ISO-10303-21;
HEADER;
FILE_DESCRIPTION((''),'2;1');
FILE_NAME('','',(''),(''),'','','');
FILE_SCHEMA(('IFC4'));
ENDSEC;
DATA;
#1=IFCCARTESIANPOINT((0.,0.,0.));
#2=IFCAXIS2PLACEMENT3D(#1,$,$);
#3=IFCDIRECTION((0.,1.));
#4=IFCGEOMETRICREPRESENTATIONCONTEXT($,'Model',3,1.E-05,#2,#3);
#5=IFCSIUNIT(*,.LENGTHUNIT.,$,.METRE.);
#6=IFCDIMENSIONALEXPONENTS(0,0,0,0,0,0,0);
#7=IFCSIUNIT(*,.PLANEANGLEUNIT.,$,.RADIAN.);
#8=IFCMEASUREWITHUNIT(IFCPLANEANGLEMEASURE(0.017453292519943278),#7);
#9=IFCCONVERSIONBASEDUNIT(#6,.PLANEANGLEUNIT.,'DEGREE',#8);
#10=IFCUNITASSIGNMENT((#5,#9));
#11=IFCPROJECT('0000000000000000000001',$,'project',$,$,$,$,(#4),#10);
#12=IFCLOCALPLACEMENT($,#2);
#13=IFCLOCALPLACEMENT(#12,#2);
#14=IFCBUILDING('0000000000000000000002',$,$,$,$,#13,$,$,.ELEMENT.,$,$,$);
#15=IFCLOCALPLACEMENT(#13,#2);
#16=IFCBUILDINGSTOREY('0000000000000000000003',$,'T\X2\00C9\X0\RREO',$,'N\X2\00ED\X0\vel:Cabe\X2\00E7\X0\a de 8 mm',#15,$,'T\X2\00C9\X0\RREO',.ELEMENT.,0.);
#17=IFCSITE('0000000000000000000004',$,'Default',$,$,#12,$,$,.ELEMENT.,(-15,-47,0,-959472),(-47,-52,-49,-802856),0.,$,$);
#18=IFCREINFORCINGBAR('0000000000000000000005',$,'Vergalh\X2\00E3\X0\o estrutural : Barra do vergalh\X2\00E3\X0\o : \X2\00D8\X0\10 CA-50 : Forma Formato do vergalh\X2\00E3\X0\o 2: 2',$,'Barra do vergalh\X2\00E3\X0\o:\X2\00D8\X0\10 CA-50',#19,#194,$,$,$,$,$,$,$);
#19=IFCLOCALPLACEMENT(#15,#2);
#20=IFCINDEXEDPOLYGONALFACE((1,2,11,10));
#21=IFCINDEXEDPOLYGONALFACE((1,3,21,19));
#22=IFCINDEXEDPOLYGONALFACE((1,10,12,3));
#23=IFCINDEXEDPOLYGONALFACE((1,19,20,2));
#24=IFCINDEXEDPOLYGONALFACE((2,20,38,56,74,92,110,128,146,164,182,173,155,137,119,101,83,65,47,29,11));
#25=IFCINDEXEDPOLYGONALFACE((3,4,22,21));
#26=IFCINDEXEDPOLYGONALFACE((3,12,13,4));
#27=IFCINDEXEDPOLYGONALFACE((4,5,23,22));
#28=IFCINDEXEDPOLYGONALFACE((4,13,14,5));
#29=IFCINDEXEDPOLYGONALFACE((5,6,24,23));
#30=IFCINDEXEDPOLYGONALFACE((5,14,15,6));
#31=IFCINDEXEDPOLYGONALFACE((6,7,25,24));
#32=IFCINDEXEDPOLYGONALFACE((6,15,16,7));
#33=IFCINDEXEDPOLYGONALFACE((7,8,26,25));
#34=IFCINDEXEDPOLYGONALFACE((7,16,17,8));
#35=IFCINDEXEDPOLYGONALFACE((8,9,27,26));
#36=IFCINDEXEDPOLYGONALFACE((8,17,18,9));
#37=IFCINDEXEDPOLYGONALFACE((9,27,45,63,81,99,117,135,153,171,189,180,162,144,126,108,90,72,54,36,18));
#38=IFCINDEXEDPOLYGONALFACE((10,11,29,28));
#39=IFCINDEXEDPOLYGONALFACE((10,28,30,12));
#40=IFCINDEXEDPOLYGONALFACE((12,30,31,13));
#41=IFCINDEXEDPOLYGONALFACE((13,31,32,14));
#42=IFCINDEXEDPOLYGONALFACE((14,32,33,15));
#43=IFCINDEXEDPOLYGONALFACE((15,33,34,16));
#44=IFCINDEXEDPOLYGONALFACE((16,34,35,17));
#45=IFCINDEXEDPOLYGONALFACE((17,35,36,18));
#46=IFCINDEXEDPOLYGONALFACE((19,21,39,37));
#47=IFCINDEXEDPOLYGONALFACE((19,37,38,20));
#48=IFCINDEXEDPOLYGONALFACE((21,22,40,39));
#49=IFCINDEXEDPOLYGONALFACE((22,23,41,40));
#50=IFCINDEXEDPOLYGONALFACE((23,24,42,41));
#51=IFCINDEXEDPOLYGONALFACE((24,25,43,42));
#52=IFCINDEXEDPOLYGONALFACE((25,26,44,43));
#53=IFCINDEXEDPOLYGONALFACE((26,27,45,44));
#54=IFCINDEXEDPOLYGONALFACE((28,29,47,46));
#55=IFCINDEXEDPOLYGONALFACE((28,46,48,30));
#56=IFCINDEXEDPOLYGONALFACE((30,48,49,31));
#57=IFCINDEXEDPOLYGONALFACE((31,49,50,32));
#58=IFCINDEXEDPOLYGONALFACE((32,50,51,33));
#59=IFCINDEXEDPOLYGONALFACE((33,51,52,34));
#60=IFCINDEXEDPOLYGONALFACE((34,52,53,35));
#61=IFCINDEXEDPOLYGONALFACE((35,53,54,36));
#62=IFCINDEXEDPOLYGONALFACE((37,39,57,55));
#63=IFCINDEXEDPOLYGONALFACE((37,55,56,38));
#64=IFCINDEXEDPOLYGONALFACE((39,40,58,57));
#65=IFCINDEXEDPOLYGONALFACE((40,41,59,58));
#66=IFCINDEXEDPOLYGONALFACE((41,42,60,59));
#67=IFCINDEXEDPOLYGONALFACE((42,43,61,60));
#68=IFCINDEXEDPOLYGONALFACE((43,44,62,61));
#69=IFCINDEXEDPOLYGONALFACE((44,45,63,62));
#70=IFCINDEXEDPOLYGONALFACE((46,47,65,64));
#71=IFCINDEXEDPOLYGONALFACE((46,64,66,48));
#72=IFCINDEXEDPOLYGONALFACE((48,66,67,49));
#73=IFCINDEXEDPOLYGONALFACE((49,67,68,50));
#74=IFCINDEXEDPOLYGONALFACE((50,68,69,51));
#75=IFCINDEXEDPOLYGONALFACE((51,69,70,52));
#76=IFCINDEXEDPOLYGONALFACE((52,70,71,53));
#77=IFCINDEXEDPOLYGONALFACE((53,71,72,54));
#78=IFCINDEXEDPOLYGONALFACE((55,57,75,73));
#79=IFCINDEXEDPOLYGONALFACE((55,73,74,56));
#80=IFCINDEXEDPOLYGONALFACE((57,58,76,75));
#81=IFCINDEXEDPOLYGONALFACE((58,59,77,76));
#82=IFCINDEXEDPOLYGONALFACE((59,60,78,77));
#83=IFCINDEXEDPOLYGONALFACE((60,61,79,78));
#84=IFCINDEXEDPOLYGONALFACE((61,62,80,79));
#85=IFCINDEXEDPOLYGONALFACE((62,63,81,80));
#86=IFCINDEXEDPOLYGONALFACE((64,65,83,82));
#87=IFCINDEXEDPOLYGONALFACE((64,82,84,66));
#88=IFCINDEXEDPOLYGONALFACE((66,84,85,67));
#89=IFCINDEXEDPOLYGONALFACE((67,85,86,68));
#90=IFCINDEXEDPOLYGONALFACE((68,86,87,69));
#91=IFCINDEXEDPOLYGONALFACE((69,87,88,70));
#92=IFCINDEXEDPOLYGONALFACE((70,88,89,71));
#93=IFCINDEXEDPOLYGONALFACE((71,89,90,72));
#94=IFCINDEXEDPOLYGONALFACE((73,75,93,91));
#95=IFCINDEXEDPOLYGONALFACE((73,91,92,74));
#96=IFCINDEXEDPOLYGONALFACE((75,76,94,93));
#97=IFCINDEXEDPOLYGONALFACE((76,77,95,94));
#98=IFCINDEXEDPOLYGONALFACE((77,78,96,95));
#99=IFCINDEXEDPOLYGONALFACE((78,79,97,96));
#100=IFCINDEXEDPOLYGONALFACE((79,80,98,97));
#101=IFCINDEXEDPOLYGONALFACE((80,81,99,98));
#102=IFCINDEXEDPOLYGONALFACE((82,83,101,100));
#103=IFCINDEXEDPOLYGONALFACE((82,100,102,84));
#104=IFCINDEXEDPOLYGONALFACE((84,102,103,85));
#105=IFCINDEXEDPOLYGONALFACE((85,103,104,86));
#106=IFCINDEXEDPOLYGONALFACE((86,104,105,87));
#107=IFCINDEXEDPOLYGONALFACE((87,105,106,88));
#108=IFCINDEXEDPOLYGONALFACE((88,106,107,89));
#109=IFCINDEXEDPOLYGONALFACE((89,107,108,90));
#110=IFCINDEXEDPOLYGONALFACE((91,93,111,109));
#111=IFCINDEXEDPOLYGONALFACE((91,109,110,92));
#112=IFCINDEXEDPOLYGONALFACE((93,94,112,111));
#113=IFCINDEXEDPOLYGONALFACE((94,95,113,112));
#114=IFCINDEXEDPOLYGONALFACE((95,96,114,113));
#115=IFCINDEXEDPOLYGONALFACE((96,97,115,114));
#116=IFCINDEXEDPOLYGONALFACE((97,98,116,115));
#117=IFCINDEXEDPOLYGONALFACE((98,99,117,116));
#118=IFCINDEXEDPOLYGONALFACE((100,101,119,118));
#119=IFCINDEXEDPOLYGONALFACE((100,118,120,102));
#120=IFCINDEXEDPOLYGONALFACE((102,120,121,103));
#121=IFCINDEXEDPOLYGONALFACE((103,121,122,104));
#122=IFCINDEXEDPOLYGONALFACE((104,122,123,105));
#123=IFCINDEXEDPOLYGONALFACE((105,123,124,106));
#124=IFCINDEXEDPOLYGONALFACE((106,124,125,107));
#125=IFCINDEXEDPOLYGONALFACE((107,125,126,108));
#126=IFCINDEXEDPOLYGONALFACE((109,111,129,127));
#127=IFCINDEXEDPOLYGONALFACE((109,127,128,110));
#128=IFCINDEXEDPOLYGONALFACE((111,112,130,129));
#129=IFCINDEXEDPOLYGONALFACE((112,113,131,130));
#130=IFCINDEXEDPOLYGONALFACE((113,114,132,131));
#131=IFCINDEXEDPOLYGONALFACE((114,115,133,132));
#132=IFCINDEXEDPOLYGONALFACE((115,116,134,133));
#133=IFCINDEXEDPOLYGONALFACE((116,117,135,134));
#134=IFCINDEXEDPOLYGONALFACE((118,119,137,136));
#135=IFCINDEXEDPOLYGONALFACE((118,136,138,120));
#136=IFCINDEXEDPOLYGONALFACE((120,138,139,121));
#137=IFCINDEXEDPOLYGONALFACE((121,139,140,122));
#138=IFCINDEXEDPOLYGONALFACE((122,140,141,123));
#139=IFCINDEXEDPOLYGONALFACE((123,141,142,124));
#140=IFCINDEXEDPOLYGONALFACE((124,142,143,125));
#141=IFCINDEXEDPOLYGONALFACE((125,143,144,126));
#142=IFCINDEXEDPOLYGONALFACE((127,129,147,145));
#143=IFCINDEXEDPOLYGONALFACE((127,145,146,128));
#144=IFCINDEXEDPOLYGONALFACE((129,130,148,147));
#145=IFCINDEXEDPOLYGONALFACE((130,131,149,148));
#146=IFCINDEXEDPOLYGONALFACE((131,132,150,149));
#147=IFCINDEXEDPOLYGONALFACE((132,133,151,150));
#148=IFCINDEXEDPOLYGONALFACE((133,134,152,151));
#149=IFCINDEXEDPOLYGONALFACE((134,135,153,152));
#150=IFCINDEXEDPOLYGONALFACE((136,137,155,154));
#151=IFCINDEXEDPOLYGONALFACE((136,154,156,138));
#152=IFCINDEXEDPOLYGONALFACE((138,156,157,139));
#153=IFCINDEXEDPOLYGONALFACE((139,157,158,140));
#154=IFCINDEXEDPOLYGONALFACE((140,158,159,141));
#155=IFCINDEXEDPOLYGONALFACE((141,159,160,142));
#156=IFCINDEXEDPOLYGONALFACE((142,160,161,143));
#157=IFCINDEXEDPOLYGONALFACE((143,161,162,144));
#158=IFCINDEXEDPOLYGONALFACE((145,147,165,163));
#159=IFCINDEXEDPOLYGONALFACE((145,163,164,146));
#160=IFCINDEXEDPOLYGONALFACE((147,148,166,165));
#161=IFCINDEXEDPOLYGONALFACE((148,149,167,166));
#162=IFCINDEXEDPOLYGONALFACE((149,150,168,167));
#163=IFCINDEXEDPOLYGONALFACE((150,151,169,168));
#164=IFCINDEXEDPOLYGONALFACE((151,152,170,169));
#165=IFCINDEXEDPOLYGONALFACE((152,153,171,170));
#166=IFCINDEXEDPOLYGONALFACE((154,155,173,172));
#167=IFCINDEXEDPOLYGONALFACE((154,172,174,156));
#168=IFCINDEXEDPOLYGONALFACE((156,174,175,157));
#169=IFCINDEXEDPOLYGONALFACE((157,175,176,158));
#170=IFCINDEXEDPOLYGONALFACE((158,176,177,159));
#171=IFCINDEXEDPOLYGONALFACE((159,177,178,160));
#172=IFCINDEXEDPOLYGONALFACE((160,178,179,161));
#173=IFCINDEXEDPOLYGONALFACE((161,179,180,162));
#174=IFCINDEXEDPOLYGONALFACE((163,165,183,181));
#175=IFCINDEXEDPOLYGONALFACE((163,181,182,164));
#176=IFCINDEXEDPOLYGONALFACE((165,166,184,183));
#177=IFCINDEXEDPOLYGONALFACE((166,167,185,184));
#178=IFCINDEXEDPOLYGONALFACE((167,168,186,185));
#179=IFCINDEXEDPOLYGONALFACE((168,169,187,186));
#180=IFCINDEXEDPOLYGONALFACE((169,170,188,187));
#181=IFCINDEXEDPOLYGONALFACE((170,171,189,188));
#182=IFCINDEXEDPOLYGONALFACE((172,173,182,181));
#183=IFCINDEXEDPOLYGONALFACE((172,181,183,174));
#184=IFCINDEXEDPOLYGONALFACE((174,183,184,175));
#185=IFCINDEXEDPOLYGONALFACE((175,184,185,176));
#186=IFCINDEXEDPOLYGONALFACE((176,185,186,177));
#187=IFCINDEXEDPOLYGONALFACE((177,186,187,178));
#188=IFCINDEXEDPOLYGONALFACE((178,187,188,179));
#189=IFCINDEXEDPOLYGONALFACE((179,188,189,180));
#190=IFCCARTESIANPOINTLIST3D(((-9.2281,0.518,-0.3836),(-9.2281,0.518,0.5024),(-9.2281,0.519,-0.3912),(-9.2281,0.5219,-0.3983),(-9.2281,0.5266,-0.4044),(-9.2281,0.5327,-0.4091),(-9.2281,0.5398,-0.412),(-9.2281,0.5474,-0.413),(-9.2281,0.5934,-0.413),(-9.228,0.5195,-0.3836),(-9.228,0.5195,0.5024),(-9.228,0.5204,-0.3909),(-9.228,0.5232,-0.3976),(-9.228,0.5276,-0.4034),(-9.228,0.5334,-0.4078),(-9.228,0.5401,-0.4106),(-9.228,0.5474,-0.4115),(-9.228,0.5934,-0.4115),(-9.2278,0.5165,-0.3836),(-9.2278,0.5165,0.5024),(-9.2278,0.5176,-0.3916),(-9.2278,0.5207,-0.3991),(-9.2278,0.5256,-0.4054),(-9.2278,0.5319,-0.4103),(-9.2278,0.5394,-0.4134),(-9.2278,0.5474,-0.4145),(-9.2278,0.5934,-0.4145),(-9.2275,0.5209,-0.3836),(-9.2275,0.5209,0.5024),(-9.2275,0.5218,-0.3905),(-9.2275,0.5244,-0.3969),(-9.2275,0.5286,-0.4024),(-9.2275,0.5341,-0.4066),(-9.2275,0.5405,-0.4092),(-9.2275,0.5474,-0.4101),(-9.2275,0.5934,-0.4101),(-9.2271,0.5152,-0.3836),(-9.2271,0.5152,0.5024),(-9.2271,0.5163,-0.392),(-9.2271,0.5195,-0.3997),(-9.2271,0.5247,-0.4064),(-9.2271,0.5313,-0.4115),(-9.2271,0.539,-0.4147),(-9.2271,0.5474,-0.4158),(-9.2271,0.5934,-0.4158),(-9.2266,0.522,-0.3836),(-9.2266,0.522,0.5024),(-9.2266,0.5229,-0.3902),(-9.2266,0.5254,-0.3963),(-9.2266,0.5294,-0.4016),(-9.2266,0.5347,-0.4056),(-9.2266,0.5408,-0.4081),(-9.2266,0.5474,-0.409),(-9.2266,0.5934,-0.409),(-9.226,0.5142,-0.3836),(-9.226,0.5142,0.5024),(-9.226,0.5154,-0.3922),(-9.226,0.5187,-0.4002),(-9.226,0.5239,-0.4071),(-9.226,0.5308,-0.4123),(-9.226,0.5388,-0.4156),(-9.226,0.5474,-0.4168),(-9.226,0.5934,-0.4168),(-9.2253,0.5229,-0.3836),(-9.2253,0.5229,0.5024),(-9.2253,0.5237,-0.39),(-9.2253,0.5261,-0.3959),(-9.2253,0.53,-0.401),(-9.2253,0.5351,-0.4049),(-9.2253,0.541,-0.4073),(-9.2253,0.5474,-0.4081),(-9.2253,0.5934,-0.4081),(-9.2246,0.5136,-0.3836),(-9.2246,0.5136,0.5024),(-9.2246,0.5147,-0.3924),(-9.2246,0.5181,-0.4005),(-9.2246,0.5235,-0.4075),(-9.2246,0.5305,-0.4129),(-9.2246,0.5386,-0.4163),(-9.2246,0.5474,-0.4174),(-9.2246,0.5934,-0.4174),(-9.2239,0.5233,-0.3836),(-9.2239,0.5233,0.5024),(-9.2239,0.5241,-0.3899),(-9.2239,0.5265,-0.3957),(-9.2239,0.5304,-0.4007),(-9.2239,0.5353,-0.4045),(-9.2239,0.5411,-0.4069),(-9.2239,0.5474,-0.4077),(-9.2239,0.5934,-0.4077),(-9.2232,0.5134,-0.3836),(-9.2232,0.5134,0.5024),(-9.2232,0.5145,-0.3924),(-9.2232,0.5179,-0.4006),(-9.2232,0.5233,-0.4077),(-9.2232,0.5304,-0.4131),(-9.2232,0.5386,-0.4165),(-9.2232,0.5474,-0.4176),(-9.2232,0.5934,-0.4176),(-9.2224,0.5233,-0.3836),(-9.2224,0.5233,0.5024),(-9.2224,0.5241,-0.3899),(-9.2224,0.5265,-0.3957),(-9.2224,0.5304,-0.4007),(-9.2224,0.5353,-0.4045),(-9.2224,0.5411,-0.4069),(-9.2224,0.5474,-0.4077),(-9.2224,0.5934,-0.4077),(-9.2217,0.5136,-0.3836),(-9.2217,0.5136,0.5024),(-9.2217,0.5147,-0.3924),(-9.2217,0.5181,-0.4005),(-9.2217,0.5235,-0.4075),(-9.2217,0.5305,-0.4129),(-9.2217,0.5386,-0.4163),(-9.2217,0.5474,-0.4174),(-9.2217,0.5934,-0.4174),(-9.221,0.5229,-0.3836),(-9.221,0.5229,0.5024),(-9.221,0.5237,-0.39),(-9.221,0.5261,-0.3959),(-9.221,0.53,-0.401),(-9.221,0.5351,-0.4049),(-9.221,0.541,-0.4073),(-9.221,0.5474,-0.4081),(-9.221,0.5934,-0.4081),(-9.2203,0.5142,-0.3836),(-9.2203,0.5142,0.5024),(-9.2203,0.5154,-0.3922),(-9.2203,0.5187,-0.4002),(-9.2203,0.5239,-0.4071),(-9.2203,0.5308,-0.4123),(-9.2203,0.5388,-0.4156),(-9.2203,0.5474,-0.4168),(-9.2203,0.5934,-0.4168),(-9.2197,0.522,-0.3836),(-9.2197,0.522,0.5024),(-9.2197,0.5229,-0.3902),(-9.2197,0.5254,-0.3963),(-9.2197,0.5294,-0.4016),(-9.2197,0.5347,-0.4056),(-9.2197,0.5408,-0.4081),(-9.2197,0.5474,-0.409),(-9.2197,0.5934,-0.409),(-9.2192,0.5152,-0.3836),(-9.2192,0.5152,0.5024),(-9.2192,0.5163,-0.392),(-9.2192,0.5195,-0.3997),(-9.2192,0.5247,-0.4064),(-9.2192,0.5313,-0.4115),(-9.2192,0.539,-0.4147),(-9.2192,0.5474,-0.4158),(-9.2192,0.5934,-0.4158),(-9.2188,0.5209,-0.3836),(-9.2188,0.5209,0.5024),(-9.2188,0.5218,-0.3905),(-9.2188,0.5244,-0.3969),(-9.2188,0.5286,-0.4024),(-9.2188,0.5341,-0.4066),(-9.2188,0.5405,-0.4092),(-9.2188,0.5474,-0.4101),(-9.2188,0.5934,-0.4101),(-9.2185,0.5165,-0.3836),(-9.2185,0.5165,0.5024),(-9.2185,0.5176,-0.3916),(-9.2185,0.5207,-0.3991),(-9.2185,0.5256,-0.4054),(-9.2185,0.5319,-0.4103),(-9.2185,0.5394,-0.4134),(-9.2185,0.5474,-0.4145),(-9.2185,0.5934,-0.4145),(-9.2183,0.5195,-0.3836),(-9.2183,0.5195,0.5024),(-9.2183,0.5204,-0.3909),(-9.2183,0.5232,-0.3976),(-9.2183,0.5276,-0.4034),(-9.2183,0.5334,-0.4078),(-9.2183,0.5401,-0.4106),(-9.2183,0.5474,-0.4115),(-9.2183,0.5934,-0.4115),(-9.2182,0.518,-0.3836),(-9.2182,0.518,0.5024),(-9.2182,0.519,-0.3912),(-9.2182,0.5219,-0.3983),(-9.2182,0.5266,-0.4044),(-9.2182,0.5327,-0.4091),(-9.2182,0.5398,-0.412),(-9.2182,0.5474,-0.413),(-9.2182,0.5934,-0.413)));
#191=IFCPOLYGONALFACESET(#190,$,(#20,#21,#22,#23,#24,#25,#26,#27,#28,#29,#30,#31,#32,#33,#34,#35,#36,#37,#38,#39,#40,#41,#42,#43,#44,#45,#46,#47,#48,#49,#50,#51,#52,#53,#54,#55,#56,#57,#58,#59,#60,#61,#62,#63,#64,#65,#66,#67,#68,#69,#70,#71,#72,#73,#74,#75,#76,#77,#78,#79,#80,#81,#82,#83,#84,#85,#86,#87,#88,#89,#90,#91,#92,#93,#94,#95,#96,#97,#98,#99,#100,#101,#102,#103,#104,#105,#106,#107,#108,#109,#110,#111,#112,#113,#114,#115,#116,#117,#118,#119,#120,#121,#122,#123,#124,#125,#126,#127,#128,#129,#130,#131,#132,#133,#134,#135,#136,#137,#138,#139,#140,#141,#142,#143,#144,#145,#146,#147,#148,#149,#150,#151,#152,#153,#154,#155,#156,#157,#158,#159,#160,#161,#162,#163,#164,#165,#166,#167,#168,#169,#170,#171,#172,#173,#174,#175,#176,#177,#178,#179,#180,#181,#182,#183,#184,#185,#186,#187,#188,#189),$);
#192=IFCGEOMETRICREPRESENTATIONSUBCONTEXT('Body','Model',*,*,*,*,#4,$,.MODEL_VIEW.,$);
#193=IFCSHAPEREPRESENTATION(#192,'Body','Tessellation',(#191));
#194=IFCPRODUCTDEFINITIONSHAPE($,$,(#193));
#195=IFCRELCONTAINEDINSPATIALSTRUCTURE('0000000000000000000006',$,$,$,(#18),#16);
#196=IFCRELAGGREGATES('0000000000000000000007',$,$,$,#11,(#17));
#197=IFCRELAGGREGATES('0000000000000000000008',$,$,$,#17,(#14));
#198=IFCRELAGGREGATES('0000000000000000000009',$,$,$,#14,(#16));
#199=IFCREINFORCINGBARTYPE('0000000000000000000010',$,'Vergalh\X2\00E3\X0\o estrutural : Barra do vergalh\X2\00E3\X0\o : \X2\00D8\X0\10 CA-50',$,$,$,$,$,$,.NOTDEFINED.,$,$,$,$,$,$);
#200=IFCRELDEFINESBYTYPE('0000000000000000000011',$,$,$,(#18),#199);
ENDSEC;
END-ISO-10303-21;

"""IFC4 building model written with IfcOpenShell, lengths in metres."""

from ifc_helpers import new_model, entity, si_unit, converted_unit, direction, origin, place, context, subcontext, project, spatial, type_object, element, save


model = new_model("IFC4")

# Units and contexts
model_context = context("Model", 3, precision=1e-05, world=origin(), true_north=direction((0.0, 1.0)))
body_context = subcontext(model_context, "Body", "Model", "MODEL_VIEW")
ifc_project = project(units=[si_unit("LENGTHUNIT", "METRE"), converted_unit("PLANEANGLEUNIT", "DEGREE", entity("IfcPlaneAngleMeasure", 0.017453292519943278), si_unit("PLANEANGLEUNIT", "RADIAN"), dimensions=[0, 0, 0, 0, 0, 0, 0])], contexts=[model_context])

# Site, building, storey
site_placement = place(None, origin())
site = spatial("IfcSite", under=ifc_project, at=site_placement, Name="Default", CompositionType="ELEMENT", RefLatitude=(-15, -47, 0, -959472), RefLongitude=(-47, -52, -49, -802856), RefElevation=0.0)
building_placement = place(site_placement, origin())
building = spatial("IfcBuilding", under=site, at=building_placement, CompositionType="ELEMENT")
storey_placement = place(building_placement, origin())
storey = spatial("IfcBuildingStorey", under=building, at=storey_placement, Name="TÉRREO", ObjectType="Nível:Cabeça de 8 mm", LongName="TÉRREO", CompositionType="ELEMENT", Elevation=0.0)

# Reinforcing bar
reinforcing_bar_type_1 = type_object("IfcReinforcingBarType", Name="Vergalhão estrutural : Barra do vergalhão : Ø10 CA-50", PredefinedType="NOTDEFINED")
reinforcing_bar_1_placement = place(storey_placement, origin())
element("IfcReinforcingBar", 1, at=reinforcing_bar_1_placement, inside=storey, type_object=reinforcing_bar_type_1, Name="Vergalhão estrutural : Barra do vergalhão : Ø10 CA-50 : Forma Formato do vergalhão 2: 2", ObjectType="Barra do vergalhão:Ø10 CA-50", context=body_context, shape_type="AdvancedSweptSolid", body=[
    entity("IfcSweptDiskSolid", entity("IfcIndexedPolyCurve", entity("IfcCartesianPointList3D", [[-9.2232, 0.5934, -0.4126], [-9.2232, 0.5474, -0.4126], [-9.2232, 0.5269, -0.4042], [-9.2232, 0.5184, -0.3836], [-9.2232, 0.5184, 0.5024]]), [entity("IfcLineIndex", [1, 2]), entity("IfcArcIndex", [2, 3, 4]), entity("IfcLineIndex", [4, 5])], False), 0.005, None, 0.0, 92.0),
])

save(model, "model.ifc")
